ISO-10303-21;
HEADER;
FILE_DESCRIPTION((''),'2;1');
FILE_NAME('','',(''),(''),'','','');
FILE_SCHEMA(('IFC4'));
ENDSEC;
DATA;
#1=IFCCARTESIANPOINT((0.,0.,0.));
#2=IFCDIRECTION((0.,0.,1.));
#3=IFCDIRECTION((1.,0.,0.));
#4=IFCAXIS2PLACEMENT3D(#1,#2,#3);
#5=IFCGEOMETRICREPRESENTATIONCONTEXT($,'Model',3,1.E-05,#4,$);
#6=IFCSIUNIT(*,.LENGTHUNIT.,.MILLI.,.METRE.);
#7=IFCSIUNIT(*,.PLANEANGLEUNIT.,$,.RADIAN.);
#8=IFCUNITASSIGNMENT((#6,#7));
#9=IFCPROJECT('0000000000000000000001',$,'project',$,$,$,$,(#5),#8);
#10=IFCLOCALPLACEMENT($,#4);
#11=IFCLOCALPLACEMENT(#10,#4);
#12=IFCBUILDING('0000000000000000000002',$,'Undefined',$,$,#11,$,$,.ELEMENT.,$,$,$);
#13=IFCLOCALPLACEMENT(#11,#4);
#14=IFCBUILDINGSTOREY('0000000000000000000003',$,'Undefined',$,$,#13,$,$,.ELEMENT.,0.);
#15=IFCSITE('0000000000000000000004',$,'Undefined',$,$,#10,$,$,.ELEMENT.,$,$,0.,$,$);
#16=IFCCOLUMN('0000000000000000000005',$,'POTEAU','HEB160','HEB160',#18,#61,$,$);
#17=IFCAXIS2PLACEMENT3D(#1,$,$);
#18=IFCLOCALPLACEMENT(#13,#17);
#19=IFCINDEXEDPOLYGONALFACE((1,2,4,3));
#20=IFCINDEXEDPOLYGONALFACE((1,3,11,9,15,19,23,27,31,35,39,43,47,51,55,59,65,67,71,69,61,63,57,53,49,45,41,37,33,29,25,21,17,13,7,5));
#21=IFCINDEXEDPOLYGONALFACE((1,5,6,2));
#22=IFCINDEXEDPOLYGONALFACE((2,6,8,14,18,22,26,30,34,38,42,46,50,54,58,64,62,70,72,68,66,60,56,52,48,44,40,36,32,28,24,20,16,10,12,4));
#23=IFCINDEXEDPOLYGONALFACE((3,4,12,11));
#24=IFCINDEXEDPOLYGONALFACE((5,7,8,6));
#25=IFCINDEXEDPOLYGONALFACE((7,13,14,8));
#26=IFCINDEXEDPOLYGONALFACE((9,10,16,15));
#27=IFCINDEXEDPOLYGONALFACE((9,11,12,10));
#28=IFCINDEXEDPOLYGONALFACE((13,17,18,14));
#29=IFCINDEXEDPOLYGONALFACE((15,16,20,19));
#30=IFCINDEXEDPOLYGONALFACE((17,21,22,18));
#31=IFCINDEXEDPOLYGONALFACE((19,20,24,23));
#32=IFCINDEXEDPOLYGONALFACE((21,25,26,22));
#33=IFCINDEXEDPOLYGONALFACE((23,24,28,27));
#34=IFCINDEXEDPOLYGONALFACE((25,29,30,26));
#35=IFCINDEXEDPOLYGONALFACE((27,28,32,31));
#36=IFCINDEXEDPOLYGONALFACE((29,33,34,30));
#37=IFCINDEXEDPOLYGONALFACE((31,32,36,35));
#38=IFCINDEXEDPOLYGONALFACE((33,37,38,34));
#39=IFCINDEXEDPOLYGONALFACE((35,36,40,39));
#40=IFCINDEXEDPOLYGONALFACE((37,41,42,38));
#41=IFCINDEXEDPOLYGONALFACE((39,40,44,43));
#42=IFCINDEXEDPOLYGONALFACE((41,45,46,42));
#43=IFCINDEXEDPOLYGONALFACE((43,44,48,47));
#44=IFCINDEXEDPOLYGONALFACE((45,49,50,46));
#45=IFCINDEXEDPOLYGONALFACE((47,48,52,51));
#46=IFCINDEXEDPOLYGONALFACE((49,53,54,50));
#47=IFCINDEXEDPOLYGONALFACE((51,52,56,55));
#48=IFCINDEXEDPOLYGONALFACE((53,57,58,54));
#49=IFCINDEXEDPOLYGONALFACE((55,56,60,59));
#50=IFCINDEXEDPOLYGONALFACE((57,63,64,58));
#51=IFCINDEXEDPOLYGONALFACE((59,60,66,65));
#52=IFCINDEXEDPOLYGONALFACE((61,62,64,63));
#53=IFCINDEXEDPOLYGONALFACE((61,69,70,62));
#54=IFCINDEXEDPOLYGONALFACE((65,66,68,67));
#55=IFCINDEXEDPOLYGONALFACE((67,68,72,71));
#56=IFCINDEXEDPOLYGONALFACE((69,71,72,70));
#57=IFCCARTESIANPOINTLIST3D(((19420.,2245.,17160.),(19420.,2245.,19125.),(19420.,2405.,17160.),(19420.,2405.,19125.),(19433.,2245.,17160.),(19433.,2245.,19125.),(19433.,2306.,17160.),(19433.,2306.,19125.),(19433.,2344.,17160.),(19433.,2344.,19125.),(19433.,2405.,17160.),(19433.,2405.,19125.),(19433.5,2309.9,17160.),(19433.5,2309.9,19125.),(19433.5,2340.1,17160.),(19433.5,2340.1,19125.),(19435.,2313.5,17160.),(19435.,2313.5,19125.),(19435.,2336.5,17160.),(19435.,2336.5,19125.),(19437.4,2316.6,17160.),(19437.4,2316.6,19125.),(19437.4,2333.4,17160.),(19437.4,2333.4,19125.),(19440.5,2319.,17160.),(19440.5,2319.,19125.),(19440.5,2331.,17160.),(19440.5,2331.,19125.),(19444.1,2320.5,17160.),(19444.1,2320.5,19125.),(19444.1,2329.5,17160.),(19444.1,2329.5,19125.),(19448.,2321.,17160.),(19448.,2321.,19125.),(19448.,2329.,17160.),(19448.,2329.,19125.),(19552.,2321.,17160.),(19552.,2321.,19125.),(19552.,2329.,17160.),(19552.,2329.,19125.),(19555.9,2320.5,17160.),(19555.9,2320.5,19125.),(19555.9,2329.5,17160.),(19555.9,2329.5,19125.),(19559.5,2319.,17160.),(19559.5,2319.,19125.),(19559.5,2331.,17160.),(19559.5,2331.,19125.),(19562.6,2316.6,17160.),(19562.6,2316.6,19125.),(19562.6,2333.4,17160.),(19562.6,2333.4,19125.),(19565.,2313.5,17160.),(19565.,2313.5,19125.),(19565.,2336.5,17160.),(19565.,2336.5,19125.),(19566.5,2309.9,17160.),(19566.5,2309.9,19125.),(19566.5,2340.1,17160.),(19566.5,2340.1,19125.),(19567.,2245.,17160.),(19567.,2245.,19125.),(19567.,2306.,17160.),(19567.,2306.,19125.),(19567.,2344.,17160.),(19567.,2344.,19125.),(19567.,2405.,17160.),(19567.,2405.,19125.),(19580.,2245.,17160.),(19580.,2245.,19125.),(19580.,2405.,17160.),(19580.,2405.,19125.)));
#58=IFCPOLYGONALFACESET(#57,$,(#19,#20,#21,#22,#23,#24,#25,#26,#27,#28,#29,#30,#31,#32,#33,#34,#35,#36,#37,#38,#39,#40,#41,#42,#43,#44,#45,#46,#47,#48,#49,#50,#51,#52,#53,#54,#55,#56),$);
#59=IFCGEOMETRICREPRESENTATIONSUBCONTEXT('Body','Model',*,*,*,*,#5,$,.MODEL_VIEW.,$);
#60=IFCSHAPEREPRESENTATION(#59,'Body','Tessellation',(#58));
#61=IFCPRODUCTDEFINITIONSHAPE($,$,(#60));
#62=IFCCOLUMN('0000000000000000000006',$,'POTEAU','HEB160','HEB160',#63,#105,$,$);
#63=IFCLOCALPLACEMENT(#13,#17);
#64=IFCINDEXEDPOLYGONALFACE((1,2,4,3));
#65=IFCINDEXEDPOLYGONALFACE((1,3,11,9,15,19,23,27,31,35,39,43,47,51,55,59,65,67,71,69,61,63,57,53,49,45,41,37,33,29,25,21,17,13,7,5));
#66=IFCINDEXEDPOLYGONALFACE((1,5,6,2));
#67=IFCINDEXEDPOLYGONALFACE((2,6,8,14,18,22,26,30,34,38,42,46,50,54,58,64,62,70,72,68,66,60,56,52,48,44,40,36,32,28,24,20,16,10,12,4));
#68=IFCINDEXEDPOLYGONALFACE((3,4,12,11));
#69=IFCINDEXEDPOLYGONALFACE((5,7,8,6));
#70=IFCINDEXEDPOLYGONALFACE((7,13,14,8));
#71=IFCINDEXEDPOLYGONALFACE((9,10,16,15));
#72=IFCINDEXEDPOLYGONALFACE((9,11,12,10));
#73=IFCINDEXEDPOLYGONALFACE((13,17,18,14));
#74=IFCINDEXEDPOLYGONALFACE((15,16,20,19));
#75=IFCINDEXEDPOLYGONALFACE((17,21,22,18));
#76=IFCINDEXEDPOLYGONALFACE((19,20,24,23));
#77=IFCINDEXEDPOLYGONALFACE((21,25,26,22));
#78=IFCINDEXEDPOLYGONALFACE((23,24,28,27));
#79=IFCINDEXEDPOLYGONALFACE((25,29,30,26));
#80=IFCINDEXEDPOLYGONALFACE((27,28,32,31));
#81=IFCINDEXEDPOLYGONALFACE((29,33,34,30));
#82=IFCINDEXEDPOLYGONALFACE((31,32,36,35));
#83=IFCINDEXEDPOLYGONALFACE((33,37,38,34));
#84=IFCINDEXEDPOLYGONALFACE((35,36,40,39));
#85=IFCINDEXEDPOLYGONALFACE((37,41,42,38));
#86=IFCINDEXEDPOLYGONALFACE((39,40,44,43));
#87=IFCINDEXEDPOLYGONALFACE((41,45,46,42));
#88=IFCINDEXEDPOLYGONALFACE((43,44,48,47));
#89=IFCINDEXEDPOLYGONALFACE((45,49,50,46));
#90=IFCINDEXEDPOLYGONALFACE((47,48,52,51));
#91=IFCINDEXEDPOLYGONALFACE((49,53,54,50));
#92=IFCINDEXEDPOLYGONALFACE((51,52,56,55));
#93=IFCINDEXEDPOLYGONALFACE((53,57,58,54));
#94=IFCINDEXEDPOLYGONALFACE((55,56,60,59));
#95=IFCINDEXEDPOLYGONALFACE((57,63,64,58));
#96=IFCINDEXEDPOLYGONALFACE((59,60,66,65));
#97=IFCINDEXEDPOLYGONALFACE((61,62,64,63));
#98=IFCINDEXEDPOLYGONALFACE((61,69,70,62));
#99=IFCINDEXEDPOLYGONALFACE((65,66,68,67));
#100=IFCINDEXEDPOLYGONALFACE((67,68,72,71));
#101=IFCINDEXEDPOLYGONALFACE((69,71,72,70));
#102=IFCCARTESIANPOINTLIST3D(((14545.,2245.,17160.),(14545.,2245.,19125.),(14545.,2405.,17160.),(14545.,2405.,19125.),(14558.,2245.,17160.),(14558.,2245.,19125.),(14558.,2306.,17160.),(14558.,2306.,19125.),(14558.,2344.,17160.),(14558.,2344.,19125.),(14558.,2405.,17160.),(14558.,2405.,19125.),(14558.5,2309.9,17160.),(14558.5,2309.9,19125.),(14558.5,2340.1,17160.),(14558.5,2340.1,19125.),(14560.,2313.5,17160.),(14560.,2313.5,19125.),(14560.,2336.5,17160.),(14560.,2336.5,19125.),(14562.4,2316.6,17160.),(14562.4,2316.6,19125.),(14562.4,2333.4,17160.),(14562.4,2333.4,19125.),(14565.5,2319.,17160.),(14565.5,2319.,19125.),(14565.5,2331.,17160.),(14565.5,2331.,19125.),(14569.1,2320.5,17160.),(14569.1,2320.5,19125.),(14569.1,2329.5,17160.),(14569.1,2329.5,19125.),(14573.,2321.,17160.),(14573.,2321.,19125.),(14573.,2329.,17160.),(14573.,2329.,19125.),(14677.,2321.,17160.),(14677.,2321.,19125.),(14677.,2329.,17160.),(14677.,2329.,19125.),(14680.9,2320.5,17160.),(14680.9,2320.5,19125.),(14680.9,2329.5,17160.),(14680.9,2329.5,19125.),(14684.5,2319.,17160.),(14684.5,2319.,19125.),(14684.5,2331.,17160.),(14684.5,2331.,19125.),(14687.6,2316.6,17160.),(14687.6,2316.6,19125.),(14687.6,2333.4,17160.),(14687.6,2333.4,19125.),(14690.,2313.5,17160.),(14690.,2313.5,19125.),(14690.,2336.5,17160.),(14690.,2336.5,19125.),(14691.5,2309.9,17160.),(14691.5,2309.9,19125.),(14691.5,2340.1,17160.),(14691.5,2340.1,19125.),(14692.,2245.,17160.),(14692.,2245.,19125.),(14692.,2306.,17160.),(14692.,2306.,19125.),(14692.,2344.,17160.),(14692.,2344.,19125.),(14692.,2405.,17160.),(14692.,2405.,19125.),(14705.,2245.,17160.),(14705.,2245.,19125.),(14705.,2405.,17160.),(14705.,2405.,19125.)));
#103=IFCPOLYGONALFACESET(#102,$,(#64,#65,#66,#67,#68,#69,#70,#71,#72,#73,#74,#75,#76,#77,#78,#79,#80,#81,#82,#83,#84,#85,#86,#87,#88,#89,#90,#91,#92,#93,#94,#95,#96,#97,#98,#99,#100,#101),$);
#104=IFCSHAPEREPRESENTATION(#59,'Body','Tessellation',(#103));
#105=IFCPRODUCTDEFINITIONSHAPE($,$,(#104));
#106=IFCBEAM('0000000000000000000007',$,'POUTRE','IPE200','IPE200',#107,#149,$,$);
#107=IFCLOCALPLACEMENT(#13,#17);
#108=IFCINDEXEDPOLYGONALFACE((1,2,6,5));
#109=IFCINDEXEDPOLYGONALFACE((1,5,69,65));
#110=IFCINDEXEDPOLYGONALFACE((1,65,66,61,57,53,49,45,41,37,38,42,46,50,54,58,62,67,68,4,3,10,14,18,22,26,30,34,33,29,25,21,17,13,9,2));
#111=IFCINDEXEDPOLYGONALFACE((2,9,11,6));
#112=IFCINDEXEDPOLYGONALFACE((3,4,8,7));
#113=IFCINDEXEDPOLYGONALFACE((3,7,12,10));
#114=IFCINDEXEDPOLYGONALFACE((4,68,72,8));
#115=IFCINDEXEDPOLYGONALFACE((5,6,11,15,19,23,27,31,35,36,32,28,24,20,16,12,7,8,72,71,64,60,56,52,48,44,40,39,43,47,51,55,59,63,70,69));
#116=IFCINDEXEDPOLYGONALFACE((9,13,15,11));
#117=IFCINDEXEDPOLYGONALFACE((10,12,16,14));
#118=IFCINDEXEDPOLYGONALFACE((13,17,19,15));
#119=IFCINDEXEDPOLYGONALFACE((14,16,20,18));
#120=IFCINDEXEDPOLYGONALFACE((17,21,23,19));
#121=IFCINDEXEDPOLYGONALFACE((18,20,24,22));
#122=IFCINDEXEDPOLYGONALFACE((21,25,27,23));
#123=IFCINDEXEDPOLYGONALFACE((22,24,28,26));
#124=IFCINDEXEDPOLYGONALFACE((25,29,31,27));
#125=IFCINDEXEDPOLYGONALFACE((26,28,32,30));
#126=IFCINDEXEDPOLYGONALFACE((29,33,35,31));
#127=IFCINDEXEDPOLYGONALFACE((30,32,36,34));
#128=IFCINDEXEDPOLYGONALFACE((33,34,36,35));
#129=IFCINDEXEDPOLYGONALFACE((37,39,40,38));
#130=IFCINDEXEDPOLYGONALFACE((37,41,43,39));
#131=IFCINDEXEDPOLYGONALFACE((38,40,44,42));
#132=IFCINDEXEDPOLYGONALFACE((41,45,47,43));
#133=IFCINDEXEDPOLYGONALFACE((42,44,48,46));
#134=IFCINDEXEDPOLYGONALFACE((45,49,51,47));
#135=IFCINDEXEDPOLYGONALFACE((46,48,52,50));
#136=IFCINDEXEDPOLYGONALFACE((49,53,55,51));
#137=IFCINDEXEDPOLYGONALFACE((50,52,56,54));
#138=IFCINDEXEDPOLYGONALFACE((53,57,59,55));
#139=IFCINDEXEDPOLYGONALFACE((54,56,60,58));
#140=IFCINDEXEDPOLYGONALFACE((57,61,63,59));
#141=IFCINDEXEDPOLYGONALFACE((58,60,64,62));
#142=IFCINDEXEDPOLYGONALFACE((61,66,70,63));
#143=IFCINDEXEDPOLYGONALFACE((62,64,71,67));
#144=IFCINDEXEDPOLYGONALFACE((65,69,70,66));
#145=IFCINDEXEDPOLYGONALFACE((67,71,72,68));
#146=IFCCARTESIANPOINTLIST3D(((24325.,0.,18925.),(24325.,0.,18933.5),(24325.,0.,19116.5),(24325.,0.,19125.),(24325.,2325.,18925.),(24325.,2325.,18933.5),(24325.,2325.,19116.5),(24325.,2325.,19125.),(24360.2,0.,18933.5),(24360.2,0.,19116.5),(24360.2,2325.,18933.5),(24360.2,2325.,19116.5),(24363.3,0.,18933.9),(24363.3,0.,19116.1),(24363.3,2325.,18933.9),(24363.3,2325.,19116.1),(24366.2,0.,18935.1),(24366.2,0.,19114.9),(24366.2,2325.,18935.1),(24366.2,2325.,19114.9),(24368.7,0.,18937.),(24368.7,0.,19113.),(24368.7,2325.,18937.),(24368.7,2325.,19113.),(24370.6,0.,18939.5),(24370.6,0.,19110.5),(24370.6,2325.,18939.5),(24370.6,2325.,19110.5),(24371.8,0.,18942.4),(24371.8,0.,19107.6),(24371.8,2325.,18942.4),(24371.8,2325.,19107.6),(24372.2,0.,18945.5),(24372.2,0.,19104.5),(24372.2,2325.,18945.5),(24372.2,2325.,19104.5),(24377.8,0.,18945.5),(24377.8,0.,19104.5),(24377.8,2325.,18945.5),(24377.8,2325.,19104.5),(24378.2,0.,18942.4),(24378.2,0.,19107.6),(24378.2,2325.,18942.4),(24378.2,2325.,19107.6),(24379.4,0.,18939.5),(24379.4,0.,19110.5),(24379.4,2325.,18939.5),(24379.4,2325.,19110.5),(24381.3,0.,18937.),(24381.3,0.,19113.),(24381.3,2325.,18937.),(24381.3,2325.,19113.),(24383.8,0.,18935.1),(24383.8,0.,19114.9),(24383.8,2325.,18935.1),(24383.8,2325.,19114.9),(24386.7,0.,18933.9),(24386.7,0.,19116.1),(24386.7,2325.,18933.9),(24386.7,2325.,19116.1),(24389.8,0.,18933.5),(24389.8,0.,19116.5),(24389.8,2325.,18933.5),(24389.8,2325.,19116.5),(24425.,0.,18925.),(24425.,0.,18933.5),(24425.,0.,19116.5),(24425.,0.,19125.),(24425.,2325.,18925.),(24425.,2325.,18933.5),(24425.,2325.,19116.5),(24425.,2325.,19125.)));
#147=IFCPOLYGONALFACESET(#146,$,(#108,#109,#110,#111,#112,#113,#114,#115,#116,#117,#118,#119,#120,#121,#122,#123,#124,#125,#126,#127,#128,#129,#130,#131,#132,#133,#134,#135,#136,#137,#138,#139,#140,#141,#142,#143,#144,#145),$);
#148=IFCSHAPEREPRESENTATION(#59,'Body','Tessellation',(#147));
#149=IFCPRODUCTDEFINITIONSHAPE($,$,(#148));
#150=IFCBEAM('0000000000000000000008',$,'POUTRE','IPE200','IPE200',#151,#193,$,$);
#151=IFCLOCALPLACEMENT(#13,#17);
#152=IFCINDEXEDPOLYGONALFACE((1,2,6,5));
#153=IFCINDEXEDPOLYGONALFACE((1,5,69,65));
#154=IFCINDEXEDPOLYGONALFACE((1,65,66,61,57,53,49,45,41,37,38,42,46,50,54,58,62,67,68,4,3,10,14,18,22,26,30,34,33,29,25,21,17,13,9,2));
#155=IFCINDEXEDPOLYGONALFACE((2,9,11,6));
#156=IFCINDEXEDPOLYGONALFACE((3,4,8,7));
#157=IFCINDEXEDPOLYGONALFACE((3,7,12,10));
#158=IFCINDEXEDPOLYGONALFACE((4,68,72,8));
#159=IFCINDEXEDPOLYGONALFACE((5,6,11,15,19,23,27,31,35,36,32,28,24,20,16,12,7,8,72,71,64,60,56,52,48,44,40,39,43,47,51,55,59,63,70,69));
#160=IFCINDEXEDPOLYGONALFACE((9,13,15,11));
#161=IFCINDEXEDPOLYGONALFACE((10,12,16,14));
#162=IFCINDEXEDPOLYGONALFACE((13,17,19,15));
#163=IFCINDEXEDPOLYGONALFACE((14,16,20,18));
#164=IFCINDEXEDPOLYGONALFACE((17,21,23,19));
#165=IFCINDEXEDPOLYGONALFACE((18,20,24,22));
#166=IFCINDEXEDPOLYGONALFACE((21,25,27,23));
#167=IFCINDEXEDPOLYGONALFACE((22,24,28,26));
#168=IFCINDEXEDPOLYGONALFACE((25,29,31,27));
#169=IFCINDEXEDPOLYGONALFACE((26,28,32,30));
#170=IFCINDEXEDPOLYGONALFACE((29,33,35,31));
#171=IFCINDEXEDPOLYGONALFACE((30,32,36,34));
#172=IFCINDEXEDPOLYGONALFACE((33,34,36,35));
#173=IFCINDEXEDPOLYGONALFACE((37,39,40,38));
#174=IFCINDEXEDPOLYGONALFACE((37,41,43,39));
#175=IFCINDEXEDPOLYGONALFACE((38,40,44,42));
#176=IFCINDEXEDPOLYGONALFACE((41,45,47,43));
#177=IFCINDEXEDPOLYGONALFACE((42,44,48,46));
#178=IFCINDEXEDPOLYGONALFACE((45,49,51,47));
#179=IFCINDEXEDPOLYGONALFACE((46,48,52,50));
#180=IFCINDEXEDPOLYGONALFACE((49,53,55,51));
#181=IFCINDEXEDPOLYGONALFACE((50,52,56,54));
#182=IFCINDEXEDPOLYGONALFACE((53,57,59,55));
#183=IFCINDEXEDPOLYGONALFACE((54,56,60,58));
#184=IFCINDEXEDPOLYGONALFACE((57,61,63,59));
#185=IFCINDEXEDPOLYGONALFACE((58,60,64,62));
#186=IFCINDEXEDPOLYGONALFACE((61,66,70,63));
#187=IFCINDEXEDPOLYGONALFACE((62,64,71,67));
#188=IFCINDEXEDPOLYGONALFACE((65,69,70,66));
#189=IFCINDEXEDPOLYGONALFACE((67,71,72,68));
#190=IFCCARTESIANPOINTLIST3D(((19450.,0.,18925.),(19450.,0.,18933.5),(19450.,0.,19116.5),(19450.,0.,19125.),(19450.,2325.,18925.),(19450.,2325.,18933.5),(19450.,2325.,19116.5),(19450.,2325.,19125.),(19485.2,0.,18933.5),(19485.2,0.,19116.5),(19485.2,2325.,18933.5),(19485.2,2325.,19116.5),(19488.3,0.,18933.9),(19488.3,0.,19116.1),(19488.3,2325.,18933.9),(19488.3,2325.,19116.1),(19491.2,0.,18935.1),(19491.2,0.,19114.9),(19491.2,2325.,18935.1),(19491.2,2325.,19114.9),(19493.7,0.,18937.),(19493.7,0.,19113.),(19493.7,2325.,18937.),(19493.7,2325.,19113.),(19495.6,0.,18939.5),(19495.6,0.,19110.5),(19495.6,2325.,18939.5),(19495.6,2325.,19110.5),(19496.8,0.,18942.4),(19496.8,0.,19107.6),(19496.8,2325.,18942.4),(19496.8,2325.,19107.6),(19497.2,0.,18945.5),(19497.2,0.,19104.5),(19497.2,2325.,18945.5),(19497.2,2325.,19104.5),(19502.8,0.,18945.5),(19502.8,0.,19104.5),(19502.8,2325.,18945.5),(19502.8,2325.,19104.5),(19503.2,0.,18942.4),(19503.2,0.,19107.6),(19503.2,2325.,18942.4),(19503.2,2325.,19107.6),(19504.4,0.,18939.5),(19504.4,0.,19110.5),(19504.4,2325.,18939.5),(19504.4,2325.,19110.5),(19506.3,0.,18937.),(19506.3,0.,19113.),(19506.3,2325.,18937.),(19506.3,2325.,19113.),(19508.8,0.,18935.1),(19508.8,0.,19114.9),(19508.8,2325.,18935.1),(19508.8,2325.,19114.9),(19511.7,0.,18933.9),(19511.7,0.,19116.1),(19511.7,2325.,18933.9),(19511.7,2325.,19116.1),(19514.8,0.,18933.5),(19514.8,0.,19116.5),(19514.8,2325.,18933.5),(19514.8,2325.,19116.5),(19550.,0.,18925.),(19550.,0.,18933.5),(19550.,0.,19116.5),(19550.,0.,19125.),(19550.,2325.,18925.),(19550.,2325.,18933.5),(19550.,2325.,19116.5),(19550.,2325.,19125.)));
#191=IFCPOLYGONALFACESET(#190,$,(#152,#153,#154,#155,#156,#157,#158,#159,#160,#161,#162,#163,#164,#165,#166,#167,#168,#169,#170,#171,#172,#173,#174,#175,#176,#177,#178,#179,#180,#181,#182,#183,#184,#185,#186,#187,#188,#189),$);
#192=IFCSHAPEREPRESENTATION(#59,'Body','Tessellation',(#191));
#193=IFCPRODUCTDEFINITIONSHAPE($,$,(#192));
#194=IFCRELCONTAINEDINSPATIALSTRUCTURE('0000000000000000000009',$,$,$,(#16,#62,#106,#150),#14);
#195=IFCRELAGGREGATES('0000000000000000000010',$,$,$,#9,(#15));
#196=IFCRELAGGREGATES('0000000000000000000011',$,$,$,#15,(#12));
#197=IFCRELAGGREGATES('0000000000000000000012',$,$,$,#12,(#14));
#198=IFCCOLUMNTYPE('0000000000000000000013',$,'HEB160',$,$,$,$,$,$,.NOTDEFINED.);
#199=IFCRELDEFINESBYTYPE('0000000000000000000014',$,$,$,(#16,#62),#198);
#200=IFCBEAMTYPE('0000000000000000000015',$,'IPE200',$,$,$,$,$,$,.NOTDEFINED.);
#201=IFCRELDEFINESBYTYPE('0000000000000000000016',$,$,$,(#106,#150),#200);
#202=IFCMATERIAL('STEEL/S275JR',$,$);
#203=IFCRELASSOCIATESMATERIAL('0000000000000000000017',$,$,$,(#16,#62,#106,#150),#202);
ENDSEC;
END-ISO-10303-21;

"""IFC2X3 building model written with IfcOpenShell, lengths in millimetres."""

from ifc_helpers import new_model, si_unit, frame, origin_with_axes, origin_2d_with_axis, place, context, subcontext, project, spatial, i_section, extrude, material, type_object, element, save


model = new_model("IFC2X3")

# Units and contexts
model_context = context("Model", 3, precision=1e-05, world=origin_with_axes())
body_context = subcontext(model_context, "Body", "Model", "MODEL_VIEW")
ifc_project = project(units=[si_unit("LENGTHUNIT", "METRE", prefix="MILLI"), si_unit("PLANEANGLEUNIT", "RADIAN")], contexts=[model_context])

# Site, building, storey
site_placement = place(None, origin_with_axes())
site = spatial("IfcSite", under=ifc_project, at=site_placement, Name="Undefined", CompositionType="ELEMENT", RefElevation=0.0)
building_placement = place(site_placement, origin_with_axes())
building = spatial("IfcBuilding", under=site, at=building_placement, Name="Undefined", CompositionType="ELEMENT")
storey_placement = place(building_placement, origin_with_axes())
storey = spatial("IfcBuildingStorey", under=building, at=storey_placement, Name="Undefined", CompositionType="ELEMENT", Elevation=0.0)

# Columns
ifc_material_1 = material(Name="STEEL/S275JR")
column_type_1 = type_object("IfcColumnType", Name="HEB160", PredefinedType="NOTDEFINED")
for number, where, z_axis, x_axis, name in (
    (1, (19500.0, 2325.0, 17160.0), (0.0, 0.0, 1.0), (1.0, 0.0, 0.0), "POTEAU"),
    (2, (14625.0, 2325.0, 17160.0), (0.0, 0.0, 1.0), (1.0, 0.0, 0.0), "POTEAU"),
):
    element("IfcColumn", number, at=place(storey_placement, frame(where, z_axis=z_axis, x_axis=x_axis)), inside=storey, type_object=column_type_1, material=ifc_material_1, Name=name, Description="HEB160", ObjectType="HEB160", context=body_context, shape_type="SweptSolid", body=[
        extrude(i_section(OverallWidth=160.0, OverallDepth=160.0, WebThickness=8.0, FlangeThickness=13.0, FilletRadius=15.0, at=origin_2d_with_axis()), frame((0.0, 0.0, 1965.0), z_axis=(0.0, 0.0, -1.0), x_axis=(0.0, -1.0, 0.0)), (0.0, 0.0, 1.0), 1965.0),
    ])

# Beams
beam_type_1 = type_object("IfcBeamType", Name="IPE200", PredefinedType="NOTDEFINED")
for number, where, z_axis, x_axis, name in (
    (3, (24375.0, 0.0, 19025.0), (0.0, 0.000013, 1.0), (0.0, 1.0, -0.000013), "POUTRE"),
    (4, (19500.0, 0.0, 19025.0), (0.0, 0.000013, 1.0), (0.0, 1.0, -0.000013), "POUTRE"),
):
    element("IfcBeam", number, at=place(storey_placement, frame(where, z_axis=z_axis, x_axis=x_axis)), inside=storey, type_object=beam_type_1, material=ifc_material_1, Name=name, Description="IPE200", ObjectType="IPE200", context=body_context, shape_type="SweptSolid", body=[
        extrude(i_section(OverallWidth=100.0, OverallDepth=200.0, WebThickness=5.6, FlangeThickness=8.5, FilletRadius=12.0, at=origin_2d_with_axis()), frame((2325.0, 0.0, 0.0), z_axis=(-1.0, 0.0, 0.0), x_axis=(0.0, -1.0, 0.0)), (0.0, 0.0, 1.0), 2325.0),
    ])

save(model, "model.ifc")
